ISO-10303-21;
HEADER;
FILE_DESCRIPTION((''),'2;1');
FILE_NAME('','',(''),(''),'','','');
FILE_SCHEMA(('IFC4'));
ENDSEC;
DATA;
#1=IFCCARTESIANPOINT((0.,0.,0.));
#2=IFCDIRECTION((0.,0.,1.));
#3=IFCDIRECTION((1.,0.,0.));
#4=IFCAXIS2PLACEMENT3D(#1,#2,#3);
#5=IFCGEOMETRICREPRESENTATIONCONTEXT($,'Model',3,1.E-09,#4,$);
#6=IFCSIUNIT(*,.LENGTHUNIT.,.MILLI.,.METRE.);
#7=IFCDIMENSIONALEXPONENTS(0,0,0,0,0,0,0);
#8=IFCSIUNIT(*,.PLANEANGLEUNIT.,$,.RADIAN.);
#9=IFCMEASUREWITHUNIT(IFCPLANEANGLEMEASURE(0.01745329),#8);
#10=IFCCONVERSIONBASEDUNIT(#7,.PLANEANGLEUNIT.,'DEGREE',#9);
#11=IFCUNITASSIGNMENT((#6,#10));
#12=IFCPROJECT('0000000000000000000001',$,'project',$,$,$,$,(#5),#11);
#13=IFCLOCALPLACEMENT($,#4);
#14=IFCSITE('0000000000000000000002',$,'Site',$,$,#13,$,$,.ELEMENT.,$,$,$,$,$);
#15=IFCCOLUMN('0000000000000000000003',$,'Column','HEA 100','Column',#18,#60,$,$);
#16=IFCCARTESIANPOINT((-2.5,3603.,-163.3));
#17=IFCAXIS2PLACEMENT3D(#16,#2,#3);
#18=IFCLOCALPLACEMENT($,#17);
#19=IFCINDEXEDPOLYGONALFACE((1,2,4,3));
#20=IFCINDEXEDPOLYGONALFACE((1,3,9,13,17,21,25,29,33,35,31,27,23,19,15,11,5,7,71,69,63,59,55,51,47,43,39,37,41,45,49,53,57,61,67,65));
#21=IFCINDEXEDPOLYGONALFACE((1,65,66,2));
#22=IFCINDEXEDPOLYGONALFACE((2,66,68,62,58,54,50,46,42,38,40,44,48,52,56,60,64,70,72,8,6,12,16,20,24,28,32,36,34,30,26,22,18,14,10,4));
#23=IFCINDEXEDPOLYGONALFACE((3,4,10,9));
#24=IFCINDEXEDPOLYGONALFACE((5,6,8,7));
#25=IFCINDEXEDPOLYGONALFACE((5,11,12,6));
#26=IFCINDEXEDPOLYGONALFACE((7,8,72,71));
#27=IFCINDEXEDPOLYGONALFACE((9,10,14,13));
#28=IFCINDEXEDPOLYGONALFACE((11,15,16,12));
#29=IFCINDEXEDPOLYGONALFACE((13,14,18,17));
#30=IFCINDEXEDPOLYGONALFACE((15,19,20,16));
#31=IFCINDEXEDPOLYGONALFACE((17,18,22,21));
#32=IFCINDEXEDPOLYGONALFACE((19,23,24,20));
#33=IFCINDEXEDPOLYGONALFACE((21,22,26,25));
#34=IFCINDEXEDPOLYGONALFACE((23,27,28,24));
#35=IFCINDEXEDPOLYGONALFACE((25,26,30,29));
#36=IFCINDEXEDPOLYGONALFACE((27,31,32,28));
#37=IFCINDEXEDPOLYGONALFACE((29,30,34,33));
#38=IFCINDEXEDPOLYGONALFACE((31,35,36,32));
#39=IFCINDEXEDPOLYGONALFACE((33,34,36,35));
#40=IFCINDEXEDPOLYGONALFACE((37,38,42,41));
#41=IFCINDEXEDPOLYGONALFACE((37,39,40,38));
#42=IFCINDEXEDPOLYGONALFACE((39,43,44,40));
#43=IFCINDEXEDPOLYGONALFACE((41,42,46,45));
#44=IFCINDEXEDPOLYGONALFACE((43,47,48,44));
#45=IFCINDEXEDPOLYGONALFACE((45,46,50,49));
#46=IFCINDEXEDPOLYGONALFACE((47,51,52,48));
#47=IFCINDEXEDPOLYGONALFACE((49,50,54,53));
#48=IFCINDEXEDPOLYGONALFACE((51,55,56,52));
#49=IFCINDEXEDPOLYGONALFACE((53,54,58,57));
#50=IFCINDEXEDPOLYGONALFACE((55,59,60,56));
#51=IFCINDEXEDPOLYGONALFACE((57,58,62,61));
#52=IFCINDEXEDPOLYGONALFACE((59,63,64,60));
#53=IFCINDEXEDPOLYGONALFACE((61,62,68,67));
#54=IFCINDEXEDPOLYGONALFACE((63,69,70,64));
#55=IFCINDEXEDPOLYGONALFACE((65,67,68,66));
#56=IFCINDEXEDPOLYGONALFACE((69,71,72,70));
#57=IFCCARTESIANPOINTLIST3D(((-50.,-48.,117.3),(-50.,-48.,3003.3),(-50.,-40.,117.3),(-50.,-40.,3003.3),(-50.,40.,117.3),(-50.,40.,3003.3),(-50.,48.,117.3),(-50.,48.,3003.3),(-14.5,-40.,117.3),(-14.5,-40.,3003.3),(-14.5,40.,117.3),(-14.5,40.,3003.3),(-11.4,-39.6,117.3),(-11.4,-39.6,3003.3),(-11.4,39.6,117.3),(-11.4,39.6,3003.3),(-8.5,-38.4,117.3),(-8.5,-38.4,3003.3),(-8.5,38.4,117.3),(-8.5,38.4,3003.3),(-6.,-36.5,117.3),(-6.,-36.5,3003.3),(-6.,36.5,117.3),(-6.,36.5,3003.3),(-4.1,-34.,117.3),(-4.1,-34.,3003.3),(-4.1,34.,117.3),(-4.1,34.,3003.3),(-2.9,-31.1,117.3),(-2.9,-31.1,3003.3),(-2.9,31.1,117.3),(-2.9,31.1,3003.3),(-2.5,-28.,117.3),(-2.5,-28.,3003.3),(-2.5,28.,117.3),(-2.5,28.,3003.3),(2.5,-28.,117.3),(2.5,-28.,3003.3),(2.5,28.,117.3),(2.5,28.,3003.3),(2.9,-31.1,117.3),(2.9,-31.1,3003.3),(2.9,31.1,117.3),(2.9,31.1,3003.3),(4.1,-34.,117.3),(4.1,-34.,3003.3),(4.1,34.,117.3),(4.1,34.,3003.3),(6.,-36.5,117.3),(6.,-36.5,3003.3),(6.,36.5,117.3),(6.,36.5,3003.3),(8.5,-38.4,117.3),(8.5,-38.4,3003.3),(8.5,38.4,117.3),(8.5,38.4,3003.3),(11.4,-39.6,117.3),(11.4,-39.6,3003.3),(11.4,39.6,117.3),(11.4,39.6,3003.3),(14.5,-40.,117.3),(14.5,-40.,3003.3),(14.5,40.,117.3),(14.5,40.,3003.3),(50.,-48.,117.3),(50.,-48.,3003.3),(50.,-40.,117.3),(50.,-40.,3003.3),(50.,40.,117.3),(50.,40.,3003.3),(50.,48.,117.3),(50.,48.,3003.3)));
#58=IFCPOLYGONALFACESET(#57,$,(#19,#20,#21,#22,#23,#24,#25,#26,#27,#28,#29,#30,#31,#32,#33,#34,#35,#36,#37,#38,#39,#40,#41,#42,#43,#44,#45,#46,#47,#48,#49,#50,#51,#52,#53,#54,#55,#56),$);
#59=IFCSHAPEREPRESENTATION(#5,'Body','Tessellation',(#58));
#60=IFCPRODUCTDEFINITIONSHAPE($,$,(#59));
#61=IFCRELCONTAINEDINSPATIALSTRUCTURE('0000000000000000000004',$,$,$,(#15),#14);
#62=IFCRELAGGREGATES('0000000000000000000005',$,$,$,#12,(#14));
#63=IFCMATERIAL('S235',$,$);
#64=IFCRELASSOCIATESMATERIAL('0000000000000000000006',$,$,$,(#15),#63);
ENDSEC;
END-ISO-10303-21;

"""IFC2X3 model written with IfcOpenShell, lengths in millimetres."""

from ifc_helpers import new_model, entity, si_unit, converted_unit, frame, origin, origin_with_axes, origin_2d, place, context, project, spatial, i_section, extrude, clip, halfspace, material, element, save


model = new_model("IFC2X3")

# Units and contexts
model_context = context("Model", 3, precision=1e-09, world=origin_with_axes())
ifc_project = project(units=[si_unit("LENGTHUNIT", "METRE", prefix="MILLI"), converted_unit("PLANEANGLEUNIT", "DEGREE", entity("IfcPlaneAngleMeasure", 0.01745329), si_unit("PLANEANGLEUNIT", "RADIAN"), dimensions=[0, 0, 0, 0, 0, 0, 0])], contexts=[model_context])

# Site
site_placement = place(None, origin_with_axes())
site = spatial("IfcSite", under=ifc_project, at=site_placement, Name="Site", CompositionType="ELEMENT")

# Column
ifc_material_1 = material(Name="S235")
column_placement = place(None, frame((-2.5, 3603.0, -163.3), z_axis=(0.0, 0.0, 1.0), x_axis=(1.0, 0.0, 0.0)))
element("IfcColumn", 1, at=column_placement, inside=site, material=ifc_material_1, Name="Column", Description="HEA 100", ObjectType="Column", context=model_context, shape_type="Clipping", body=[
    clip(clip(extrude(i_section(OverallWidth=100.0, OverallDepth=96.0, WebThickness=5.0, FlangeThickness=8.0, FilletRadius=12.0, at=origin_2d()), origin(), (0.0, 0.0, 1.0), 3280.6), halfspace(frame((2.5, -3603.0, 3003.3), z_axis=(0.0, 0.0, -1.0), x_axis=(-1.0, 0.0, 0.0)), True)), halfspace(frame((2.5, -3603.0, 117.3), z_axis=(0.0, 0.0, 1.0), x_axis=(1.0, 0.0, 0.0)), True)),
])

save(model, "model.ifc")
